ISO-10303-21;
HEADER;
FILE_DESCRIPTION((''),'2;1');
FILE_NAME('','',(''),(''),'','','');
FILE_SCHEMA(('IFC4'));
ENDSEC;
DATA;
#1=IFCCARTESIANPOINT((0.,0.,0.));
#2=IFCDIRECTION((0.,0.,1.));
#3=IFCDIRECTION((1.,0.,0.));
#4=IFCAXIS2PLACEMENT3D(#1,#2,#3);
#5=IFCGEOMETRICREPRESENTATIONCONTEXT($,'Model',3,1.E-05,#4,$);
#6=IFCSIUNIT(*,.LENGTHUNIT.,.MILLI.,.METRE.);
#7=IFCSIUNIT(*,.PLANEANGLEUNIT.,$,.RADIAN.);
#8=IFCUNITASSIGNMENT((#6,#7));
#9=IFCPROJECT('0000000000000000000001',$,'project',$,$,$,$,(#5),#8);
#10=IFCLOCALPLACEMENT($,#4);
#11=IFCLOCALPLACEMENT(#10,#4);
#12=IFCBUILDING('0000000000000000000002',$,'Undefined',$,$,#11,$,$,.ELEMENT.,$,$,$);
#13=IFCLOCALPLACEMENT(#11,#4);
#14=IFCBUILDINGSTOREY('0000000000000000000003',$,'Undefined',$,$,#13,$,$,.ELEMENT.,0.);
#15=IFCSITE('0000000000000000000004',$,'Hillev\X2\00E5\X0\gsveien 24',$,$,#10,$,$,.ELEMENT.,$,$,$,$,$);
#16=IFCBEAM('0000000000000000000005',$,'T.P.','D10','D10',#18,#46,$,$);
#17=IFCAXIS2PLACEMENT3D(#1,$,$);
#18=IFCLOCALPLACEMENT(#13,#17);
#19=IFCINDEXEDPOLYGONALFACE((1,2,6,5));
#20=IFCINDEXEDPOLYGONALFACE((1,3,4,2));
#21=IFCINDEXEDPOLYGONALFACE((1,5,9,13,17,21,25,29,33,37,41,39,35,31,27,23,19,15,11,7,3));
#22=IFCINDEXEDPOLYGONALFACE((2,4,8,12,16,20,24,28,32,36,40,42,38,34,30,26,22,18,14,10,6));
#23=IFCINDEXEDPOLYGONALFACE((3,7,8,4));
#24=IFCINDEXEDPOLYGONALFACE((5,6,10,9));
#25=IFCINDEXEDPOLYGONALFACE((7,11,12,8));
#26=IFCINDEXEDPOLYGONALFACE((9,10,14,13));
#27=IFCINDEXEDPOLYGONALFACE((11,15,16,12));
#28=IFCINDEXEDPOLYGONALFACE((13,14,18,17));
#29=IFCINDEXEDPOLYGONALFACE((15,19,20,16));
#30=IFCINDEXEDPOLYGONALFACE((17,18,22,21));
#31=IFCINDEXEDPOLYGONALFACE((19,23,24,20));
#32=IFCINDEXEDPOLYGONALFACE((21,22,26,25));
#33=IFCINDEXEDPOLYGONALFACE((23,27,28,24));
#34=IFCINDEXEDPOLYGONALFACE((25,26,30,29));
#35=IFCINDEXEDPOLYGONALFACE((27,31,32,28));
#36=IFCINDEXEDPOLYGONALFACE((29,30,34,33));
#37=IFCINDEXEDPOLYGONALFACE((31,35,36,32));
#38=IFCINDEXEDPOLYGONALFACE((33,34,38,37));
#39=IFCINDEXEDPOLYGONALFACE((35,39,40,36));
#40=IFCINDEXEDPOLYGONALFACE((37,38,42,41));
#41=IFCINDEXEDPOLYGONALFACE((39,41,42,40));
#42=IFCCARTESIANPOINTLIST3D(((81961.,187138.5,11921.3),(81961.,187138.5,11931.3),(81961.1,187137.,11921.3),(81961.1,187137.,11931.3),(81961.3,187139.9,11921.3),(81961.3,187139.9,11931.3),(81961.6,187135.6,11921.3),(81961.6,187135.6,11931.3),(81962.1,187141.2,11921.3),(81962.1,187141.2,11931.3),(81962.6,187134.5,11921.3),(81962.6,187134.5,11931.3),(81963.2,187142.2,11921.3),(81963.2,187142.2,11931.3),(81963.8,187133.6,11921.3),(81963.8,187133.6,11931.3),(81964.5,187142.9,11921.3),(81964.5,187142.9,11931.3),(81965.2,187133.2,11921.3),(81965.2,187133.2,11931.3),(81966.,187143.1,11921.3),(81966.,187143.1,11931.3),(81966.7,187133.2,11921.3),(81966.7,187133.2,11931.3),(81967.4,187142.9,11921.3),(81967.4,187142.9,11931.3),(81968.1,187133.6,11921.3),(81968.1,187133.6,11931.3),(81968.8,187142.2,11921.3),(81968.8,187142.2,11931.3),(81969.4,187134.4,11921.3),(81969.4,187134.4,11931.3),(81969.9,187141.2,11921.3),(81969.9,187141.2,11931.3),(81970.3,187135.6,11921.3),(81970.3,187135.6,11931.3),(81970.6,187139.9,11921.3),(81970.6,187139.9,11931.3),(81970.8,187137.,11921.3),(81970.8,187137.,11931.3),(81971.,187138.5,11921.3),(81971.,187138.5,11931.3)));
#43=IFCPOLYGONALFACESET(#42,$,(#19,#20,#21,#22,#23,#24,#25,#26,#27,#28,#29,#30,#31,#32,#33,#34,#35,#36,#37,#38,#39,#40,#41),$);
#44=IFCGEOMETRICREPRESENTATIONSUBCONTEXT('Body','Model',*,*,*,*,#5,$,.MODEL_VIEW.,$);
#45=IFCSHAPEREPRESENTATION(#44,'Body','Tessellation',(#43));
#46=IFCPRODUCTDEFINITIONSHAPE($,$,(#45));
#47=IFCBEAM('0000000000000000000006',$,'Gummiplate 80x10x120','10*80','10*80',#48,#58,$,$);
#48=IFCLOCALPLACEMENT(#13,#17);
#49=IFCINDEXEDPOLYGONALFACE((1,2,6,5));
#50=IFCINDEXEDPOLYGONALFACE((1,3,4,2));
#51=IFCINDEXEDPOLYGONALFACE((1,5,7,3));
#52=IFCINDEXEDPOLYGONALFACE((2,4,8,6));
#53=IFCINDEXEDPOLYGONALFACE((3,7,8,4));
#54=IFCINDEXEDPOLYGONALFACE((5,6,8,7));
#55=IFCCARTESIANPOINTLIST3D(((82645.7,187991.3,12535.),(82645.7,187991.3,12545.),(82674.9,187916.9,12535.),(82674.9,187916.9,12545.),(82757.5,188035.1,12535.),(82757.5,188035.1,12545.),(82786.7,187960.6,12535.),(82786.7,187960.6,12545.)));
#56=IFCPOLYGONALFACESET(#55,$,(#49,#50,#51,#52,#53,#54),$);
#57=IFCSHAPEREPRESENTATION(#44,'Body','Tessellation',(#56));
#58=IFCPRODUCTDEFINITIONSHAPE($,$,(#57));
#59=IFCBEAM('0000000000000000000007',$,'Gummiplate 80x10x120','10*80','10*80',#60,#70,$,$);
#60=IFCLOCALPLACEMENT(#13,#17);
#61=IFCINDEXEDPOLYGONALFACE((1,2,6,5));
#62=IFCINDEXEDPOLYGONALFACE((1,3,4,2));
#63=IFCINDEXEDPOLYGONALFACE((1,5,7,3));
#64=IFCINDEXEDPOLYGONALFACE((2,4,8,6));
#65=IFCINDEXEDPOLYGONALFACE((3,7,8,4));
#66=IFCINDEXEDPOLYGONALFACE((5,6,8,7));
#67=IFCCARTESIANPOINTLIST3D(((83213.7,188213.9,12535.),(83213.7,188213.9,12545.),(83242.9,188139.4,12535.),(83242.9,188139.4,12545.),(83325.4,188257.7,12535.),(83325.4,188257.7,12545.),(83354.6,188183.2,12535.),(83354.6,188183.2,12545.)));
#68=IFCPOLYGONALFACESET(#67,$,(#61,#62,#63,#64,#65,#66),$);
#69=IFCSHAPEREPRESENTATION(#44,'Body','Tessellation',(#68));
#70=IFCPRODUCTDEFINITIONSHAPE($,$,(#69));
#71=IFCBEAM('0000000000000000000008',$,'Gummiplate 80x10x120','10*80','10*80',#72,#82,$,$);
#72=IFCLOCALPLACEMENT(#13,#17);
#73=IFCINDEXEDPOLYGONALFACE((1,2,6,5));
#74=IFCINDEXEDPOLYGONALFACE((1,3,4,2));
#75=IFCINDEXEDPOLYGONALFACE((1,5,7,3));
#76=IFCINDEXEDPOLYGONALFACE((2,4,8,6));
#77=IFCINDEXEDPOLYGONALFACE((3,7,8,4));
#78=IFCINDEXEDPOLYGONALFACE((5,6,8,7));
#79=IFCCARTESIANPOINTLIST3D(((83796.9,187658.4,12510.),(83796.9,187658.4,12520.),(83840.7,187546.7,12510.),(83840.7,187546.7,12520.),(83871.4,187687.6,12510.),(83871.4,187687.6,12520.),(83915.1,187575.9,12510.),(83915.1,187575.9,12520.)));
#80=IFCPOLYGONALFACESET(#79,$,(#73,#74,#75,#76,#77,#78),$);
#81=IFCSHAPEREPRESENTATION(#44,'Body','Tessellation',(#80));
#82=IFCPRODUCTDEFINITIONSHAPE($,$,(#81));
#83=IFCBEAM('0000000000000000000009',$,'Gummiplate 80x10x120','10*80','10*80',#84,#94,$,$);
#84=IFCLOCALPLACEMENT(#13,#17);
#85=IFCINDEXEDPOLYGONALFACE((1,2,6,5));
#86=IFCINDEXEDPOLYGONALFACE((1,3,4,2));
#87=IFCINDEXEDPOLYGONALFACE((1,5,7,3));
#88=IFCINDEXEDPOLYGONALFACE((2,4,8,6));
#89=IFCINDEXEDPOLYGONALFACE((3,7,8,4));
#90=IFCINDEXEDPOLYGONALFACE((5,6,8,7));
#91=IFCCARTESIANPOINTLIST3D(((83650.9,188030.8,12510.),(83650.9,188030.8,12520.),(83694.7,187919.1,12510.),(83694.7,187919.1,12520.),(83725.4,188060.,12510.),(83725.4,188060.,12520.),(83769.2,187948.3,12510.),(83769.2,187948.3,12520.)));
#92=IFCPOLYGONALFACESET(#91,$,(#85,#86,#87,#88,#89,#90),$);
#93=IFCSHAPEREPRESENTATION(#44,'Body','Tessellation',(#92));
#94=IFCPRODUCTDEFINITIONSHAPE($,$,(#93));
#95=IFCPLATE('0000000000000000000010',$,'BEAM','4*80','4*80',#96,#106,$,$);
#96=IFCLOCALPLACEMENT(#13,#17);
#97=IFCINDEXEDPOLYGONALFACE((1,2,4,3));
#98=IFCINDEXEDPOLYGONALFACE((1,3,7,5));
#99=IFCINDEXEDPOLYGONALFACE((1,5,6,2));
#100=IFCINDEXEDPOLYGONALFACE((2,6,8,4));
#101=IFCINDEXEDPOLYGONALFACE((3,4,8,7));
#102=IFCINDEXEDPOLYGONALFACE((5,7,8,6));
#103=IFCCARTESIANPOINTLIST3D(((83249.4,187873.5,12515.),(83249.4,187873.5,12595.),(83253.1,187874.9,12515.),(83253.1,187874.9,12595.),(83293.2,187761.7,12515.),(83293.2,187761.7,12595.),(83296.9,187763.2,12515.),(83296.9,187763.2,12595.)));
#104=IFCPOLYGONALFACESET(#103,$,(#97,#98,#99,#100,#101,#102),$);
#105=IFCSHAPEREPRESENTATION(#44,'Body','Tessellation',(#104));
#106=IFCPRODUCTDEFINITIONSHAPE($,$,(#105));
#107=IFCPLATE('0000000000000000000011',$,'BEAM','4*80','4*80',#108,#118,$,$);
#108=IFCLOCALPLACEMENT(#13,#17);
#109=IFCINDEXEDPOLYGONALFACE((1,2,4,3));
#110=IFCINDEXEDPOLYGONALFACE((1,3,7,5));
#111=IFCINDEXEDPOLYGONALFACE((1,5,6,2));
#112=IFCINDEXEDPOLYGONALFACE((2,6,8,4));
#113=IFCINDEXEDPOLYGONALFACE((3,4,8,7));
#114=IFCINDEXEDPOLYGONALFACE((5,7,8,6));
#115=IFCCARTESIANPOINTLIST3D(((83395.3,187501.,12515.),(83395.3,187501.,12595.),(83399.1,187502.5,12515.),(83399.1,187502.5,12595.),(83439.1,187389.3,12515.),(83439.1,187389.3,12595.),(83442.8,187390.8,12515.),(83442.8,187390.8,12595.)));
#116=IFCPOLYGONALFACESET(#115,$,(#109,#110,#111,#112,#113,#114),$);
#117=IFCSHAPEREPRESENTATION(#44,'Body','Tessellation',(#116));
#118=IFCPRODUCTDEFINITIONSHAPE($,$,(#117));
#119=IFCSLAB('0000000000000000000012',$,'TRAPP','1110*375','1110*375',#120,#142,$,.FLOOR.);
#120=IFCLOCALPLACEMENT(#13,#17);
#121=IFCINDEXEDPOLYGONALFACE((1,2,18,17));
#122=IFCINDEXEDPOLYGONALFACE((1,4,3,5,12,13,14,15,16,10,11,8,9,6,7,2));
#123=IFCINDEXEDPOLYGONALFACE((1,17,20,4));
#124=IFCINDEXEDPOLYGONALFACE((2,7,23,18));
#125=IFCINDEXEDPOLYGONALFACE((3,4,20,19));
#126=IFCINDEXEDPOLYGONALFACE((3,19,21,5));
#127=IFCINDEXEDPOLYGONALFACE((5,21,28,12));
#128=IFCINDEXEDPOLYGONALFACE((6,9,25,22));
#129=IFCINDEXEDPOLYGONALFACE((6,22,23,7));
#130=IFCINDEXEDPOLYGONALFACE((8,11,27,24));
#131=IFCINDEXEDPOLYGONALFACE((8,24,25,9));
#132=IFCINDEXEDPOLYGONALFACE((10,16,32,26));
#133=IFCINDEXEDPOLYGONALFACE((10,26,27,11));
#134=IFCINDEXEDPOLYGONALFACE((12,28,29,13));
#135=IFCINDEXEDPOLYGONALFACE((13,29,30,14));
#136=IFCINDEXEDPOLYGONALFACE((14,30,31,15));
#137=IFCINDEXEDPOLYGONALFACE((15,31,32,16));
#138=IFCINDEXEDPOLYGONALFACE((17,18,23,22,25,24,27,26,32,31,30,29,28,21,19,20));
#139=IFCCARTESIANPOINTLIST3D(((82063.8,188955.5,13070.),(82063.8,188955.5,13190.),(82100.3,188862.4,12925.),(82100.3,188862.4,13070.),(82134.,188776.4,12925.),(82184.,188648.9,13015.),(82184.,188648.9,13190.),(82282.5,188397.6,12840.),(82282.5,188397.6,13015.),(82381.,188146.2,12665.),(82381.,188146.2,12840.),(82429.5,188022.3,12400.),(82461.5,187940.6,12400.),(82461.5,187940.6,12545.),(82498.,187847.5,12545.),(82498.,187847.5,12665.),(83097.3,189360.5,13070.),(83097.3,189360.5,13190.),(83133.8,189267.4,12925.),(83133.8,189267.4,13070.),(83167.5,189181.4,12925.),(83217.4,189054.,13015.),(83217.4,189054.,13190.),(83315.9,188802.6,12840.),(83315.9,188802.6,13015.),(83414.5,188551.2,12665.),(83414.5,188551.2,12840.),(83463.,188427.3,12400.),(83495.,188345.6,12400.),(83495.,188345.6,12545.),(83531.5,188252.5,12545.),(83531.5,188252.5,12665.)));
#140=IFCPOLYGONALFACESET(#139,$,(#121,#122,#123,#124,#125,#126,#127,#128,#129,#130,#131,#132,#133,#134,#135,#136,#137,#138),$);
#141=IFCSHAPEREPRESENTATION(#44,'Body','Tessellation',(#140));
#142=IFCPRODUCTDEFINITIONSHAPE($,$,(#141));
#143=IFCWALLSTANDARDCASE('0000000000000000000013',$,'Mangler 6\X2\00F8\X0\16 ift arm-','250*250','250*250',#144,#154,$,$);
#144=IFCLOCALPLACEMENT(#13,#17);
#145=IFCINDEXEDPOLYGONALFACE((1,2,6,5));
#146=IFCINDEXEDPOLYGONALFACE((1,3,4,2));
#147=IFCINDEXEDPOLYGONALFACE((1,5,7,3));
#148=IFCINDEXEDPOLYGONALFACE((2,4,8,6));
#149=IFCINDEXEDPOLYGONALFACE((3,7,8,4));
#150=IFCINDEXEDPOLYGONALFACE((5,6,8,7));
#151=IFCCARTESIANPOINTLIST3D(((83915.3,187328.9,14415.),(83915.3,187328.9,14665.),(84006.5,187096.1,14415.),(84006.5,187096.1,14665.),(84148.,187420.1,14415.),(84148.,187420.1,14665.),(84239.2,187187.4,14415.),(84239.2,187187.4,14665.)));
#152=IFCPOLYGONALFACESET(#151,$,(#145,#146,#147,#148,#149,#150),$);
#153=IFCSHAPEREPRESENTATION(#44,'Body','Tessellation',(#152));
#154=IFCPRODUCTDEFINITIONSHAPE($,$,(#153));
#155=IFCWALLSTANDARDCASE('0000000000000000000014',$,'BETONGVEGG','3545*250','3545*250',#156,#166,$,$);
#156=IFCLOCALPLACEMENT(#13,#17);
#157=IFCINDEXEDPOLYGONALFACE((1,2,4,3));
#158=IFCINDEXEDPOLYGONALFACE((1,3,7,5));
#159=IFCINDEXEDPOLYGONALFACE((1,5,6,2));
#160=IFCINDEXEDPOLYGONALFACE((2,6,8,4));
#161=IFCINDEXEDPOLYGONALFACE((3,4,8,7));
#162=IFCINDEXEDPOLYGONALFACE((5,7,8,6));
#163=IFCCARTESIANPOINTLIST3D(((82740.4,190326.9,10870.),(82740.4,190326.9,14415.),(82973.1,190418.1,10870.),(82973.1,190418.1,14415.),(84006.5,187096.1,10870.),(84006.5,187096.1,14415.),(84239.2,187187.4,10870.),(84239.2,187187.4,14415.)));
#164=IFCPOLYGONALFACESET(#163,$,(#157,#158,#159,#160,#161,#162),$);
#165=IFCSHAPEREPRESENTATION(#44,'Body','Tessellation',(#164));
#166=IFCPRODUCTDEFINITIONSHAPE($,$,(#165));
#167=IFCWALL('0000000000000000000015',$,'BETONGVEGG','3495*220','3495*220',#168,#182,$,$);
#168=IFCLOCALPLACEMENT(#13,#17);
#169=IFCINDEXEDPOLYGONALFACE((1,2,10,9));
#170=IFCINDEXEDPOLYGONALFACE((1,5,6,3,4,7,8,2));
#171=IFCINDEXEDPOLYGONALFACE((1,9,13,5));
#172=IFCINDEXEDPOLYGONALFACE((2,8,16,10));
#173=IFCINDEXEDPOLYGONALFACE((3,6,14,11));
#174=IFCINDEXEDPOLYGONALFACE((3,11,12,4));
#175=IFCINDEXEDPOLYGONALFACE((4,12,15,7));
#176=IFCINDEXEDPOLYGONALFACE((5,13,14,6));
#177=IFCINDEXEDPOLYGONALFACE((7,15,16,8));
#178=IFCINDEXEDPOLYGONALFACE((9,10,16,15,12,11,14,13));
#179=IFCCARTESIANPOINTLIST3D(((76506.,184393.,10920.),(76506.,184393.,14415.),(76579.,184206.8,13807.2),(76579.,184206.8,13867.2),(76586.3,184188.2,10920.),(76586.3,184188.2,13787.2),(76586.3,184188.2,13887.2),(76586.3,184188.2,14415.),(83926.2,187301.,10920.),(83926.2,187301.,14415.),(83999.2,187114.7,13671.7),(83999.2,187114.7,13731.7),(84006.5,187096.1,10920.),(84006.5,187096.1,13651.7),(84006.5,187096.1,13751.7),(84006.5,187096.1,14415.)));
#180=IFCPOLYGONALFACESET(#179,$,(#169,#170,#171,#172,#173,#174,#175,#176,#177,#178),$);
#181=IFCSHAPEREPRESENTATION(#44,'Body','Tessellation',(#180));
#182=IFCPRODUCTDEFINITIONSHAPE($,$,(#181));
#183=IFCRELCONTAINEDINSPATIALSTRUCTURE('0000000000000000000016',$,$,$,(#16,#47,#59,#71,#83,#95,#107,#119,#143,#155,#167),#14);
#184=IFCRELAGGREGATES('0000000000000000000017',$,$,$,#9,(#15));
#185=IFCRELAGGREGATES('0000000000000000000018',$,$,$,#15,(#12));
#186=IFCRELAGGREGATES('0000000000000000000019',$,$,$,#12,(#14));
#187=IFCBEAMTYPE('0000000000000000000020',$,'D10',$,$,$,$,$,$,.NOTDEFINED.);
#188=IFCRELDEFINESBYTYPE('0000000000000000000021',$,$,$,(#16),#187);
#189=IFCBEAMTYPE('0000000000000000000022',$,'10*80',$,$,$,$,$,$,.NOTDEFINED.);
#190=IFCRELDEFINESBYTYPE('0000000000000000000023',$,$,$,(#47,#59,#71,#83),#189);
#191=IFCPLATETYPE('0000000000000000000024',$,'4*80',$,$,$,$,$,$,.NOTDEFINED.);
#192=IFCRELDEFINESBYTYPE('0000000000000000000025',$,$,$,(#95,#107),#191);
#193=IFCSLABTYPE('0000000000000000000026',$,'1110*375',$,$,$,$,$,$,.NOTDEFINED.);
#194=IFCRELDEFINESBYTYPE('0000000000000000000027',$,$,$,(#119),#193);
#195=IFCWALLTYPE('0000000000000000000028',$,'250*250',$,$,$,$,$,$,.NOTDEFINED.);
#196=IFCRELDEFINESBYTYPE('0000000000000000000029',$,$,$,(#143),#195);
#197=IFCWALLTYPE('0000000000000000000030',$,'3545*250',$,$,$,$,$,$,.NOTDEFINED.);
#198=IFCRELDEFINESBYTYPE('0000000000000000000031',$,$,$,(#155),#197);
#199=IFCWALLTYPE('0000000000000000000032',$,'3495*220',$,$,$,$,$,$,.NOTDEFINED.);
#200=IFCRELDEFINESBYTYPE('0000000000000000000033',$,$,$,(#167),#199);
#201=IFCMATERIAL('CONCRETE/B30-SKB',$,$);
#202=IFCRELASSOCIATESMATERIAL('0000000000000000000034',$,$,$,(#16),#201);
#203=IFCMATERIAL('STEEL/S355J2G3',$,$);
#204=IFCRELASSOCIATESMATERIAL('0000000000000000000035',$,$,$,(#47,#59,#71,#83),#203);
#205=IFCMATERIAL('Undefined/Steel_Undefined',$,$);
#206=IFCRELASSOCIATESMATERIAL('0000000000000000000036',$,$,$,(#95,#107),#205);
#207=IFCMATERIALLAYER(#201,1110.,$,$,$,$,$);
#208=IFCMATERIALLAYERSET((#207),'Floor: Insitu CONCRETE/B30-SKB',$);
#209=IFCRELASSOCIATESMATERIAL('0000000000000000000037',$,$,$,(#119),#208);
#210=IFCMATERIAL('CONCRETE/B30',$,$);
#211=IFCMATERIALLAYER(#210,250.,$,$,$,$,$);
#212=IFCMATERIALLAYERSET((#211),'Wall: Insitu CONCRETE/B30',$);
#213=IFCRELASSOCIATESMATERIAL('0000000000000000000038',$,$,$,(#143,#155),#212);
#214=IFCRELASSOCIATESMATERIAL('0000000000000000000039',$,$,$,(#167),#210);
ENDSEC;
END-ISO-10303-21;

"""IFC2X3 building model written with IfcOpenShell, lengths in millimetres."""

from ifc_helpers import new_model, si_unit, frame, frame_2d, origin_with_axes, place, context, subcontext, project, spatial, polyline, rectangle, circle, outline, extrude, boolean, material, layer, layer_set, layer_usage, type_object, element, save


model = new_model("IFC2X3")

# Units and contexts
model_context = context("Model", 3, precision=1e-05, world=origin_with_axes())
body_context = subcontext(model_context, "Body", "Model", "MODEL_VIEW")
ifc_project = project(units=[si_unit("LENGTHUNIT", "METRE", prefix="MILLI"), si_unit("PLANEANGLEUNIT", "RADIAN")], contexts=[model_context])

# Site, building, storey
site_placement = place(None, origin_with_axes())
site = spatial("IfcSite", under=ifc_project, at=site_placement, Name="Hillevågsveien 24", CompositionType="ELEMENT")
building_placement = place(site_placement, origin_with_axes())
building = spatial("IfcBuilding", under=site, at=building_placement, Name="Undefined", CompositionType="ELEMENT")
storey_placement = place(building_placement, origin_with_axes())
storey = spatial("IfcBuildingStorey", under=building, at=storey_placement, Name="Undefined", CompositionType="ELEMENT", Elevation=0.0)

# Beams
ifc_material_1 = material(Name="Undefined/Steel_Undefined")
ifc_material_2 = material(Name="CONCRETE/B30-SKB")
beam_type_1 = type_object("IfcBeamType", Name="D10", PredefinedType="NOTDEFINED")
for number, where, z_axis, x_axis, name in (
    (1, (81966.0, 187138.1, 11931.3), (-0.364877, 0.931056, 0.0), (0.0, 0.0, -1.0), "T.P."),
):
    element("IfcBeam", number, at=place(storey_placement, frame(where, z_axis=z_axis, x_axis=x_axis)), inside=storey, type_object=beam_type_1, material=ifc_material_2, Name=name, Description="D10", ObjectType="D10", context=body_context, shape_type="SweptSolid", body=[
        extrude(circle(Radius=5.0, at=frame_2d((0.0, 0.0), x_axis=(1.0, 0.0))), frame((10.0, 0.0, 0.0), z_axis=(-1.0, 0.0, 0.0), x_axis=(0.0, -1.0, 0.0)), (0.0, 0.0, 1.0), 10.0),
    ])
ifc_material_3 = material(Name="STEEL/S355J2G3")
beam_type_2 = type_object("IfcBeamType", Name="10*80", PredefinedType="NOTDEFINED")
for number, where, z_axis, x_axis, name in (
    (2, (82772.1, 187997.9, 12540.0), (0.0, 0.0, 1.0), (-0.931056, -0.364877, 0.0), "Gummiplate 80x10x120"),
    (3, (83340.0, 188220.5, 12540.0), (0.0, 0.0, 1.0), (-0.931056, -0.364877, 0.0), "Gummiplate 80x10x120"),
    (4, (83834.1, 187673.0, 12515.0), (0.0, 0.0, 1.0), (0.364877, -0.931056, 0.0), "Gummiplate 80x10x120"),
    (5, (83688.2, 188045.4, 12515.0), (0.0, 0.0, 1.0), (0.364877, -0.931056, 0.0), "Gummiplate 80x10x120"),
):
    element("IfcBeam", number, at=place(storey_placement, frame(where, z_axis=z_axis, x_axis=x_axis)), inside=storey, type_object=beam_type_2, material=ifc_material_3, Name=name, Description="10*80", ObjectType="10*80", context=body_context, shape_type="SweptSolid", body=[
        extrude(rectangle(XDim=80.0, YDim=10.0, at=frame_2d((0.0, 0.0), x_axis=(1.0, 0.0))), frame((120.0, 0.0, 0.0), z_axis=(-1.0, 0.0, 0.0), x_axis=(0.0, -1.0, 0.0)), (0.0, 0.0, 1.0), 120.0),
    ])

# Plates
plate_type = type_object("IfcPlateType", Name="4*80", PredefinedType="NOTDEFINED")
for number, where, z_axis, x_axis, name in (
    (6, (83295.0, 187762.5, 12595.0), (0.931056, 0.364877, 0.0), (0.0, 0.0, -1.0), "BEAM"),
    (7, (83441.0, 187390.0, 12595.0), (0.931056, 0.364877, 0.0), (0.0, 0.0, -1.0), "BEAM"),
):
    element("IfcPlate", number, at=place(storey_placement, frame(where, z_axis=z_axis, x_axis=x_axis)), inside=storey, type_object=plate_type, material=ifc_material_1, Name=name, Description="4*80", ObjectType="4*80", context=body_context, shape_type="SweptSolid", body=[
        extrude(outline(polyline([(0.0, 0.0), (80.0, 0.0), (80.0, 120.0), (0.0, 120.0), (0.0, 0.0)])), frame((0.0, 0.0, -2.0), z_axis=(0.0, 0.0, 1.0), x_axis=(1.0, 0.0, 0.0)), (0.0, 0.0, 1.0), 4.0),
    ])

# Slab
ifc_layer_1 = layer(ifc_material_2, 1110.0)
ifc_layer_set_1 = layer_set([ifc_layer_1], Name="Floor: Insitu CONCRETE/B30-SKB")
ifc_layer_usage_1 = layer_usage(ifc_layer_set_1, "AXIS3", "POSITIVE", -555.0)
slab_type = type_object("IfcSlabType", Name="1110*375", PredefinedType="NOTDEFINED")
slab_placement = place(storey_placement, frame((83014.8, 188050.0, 12665.0), z_axis=(-0.931056, -0.364877, 0.0), x_axis=(-0.364877, 0.931056, 0.0)))
element("IfcSlab", 8, at=slab_placement, inside=storey, type_object=slab_type, material=ifc_layer_usage_1, Name="TRAPP", Description="1110*375", ObjectType="1110*375", PredefinedType="FLOOR", context=body_context, shape_type="SweptSolid", body=[
    extrude(outline(polyline([(0.0, 0.0), (320.8, 0.0), (320.8, -175.0), (590.8, -175.0), (590.8, -350.0), (860.8, -350.0), (860.8, -525.0), (1190.0, -525.0), (1190.0, -405.0), (1090.0, -405.0), (1090.0, -260.0), (997.7, -260.0), (187.7, 265.0), (100.0, 265.0), (100.0, 120.0), (0.0, 120.0), (0.0, 0.0)])), frame((0.0, 0.0, -555.0), z_axis=(0.0, 0.0, 1.0), x_axis=(1.0, 0.0, 0.0)), (0.0, 0.0, 1.0), 1110.0),
])

# Walls
ifc_material_4 = material(Name="CONCRETE/B30")
ifc_layer_2 = layer(ifc_material_4, 250.0)
ifc_layer_set_2 = layer_set([ifc_layer_2], Name="Wall: Insitu CONCRETE/B30")
ifc_layer_usage_2 = layer_usage(ifc_layer_set_2, "AXIS2", "POSITIVE", -125.0)
wall_type_1 = type_object("IfcWallType", Name="250*250", PredefinedType="NOTDEFINED")
wall_1_placement = place(storey_placement, frame((84031.6, 187374.5, 14415.0), z_axis=(0.0, 0.0, 1.0), x_axis=(0.364877, -0.931056, 0.0)))
element("IfcWallStandardCase", 9, at=wall_1_placement, inside=storey, type_object=wall_type_1, material=ifc_layer_usage_2, Name="Mangler 6ø16 ift arm-", Description="250*250", ObjectType="250*250", context=body_context, shape_type="SweptSolid", body=[
    extrude(rectangle(XDim=250.0, YDim=250.0, at=frame_2d((0.0, 125.0), x_axis=(0.0, -1.0))), frame((0.0, 0.0, 0.0), z_axis=(0.0, 0.0, 1.0), x_axis=(0.0, -1.0, 0.0)), (0.0, 0.0, 1.0), 250.0),
])
ifc_layer_usage_3 = layer_usage(ifc_layer_set_2, "AXIS2", "POSITIVE", -125.0)
wall_type_2 = type_object("IfcWallType", Name="3545*250", PredefinedType="NOTDEFINED")
wall_2_placement = place(storey_placement, frame((84122.9, 187141.7, 10870.0), z_axis=(0.0, 0.0, 1.0), x_axis=(-0.364877, 0.931056, 0.0)))
element("IfcWallStandardCase", 10, at=wall_2_placement, inside=storey, type_object=wall_type_2, material=ifc_layer_usage_3, Name="BETONGVEGG", Description="3545*250", ObjectType="3545*250", context=body_context, shape_type="SweptSolid", body=[
    extrude(rectangle(XDim=3470.0, YDim=250.0, at=frame_2d((0.0, 1735.0), x_axis=(0.0, -1.0))), frame((0.0, 0.0, 0.0), z_axis=(0.0, 0.0, 1.0), x_axis=(0.0, -1.0, 0.0)), (0.0, 0.0, 1.0), 3545.0),
])
wall_type_3 = type_object("IfcWallType", Name="3495*220", PredefinedType="NOTDEFINED")
wall_3_placement = place(storey_placement, frame((83966.3, 187198.5, 10920.0), z_axis=(0.0, 0.0, 1.0), x_axis=(-0.931056, -0.364877, 0.0)))
element("IfcWall", 11, at=wall_3_placement, inside=storey, type_object=wall_type_3, material=ifc_material_4, Name="BETONGVEGG", Description="3495*220", ObjectType="3495*220", context=body_context, shape_type="CSG", body=[
    boolean("DIFFERENCE", extrude(rectangle(XDim=7969.7, YDim=220.0, at=frame_2d((0.0, 3984.8), x_axis=(0.0, -1.0))), frame((0.0, 0.0, 0.0), z_axis=(0.0, 0.0, 1.0), x_axis=(0.0, -1.0, 0.0)), (0.0, 0.0, 1.0), 3495.0), extrude(outline(polyline([(30.0, 10.0), (50.0, -10.0), (-50.0, -10.0), (-30.0, 10.0), (30.0, 10.0)])), frame((11550.0, 100.0, 2978.1), z_axis=(-0.999855, 0.0, -0.017004), x_axis=(0.017004, 0.0, -0.999855)), (0.0, 0.0, 1.0), 11701.7)),
])

save(model, "model.ifc")
